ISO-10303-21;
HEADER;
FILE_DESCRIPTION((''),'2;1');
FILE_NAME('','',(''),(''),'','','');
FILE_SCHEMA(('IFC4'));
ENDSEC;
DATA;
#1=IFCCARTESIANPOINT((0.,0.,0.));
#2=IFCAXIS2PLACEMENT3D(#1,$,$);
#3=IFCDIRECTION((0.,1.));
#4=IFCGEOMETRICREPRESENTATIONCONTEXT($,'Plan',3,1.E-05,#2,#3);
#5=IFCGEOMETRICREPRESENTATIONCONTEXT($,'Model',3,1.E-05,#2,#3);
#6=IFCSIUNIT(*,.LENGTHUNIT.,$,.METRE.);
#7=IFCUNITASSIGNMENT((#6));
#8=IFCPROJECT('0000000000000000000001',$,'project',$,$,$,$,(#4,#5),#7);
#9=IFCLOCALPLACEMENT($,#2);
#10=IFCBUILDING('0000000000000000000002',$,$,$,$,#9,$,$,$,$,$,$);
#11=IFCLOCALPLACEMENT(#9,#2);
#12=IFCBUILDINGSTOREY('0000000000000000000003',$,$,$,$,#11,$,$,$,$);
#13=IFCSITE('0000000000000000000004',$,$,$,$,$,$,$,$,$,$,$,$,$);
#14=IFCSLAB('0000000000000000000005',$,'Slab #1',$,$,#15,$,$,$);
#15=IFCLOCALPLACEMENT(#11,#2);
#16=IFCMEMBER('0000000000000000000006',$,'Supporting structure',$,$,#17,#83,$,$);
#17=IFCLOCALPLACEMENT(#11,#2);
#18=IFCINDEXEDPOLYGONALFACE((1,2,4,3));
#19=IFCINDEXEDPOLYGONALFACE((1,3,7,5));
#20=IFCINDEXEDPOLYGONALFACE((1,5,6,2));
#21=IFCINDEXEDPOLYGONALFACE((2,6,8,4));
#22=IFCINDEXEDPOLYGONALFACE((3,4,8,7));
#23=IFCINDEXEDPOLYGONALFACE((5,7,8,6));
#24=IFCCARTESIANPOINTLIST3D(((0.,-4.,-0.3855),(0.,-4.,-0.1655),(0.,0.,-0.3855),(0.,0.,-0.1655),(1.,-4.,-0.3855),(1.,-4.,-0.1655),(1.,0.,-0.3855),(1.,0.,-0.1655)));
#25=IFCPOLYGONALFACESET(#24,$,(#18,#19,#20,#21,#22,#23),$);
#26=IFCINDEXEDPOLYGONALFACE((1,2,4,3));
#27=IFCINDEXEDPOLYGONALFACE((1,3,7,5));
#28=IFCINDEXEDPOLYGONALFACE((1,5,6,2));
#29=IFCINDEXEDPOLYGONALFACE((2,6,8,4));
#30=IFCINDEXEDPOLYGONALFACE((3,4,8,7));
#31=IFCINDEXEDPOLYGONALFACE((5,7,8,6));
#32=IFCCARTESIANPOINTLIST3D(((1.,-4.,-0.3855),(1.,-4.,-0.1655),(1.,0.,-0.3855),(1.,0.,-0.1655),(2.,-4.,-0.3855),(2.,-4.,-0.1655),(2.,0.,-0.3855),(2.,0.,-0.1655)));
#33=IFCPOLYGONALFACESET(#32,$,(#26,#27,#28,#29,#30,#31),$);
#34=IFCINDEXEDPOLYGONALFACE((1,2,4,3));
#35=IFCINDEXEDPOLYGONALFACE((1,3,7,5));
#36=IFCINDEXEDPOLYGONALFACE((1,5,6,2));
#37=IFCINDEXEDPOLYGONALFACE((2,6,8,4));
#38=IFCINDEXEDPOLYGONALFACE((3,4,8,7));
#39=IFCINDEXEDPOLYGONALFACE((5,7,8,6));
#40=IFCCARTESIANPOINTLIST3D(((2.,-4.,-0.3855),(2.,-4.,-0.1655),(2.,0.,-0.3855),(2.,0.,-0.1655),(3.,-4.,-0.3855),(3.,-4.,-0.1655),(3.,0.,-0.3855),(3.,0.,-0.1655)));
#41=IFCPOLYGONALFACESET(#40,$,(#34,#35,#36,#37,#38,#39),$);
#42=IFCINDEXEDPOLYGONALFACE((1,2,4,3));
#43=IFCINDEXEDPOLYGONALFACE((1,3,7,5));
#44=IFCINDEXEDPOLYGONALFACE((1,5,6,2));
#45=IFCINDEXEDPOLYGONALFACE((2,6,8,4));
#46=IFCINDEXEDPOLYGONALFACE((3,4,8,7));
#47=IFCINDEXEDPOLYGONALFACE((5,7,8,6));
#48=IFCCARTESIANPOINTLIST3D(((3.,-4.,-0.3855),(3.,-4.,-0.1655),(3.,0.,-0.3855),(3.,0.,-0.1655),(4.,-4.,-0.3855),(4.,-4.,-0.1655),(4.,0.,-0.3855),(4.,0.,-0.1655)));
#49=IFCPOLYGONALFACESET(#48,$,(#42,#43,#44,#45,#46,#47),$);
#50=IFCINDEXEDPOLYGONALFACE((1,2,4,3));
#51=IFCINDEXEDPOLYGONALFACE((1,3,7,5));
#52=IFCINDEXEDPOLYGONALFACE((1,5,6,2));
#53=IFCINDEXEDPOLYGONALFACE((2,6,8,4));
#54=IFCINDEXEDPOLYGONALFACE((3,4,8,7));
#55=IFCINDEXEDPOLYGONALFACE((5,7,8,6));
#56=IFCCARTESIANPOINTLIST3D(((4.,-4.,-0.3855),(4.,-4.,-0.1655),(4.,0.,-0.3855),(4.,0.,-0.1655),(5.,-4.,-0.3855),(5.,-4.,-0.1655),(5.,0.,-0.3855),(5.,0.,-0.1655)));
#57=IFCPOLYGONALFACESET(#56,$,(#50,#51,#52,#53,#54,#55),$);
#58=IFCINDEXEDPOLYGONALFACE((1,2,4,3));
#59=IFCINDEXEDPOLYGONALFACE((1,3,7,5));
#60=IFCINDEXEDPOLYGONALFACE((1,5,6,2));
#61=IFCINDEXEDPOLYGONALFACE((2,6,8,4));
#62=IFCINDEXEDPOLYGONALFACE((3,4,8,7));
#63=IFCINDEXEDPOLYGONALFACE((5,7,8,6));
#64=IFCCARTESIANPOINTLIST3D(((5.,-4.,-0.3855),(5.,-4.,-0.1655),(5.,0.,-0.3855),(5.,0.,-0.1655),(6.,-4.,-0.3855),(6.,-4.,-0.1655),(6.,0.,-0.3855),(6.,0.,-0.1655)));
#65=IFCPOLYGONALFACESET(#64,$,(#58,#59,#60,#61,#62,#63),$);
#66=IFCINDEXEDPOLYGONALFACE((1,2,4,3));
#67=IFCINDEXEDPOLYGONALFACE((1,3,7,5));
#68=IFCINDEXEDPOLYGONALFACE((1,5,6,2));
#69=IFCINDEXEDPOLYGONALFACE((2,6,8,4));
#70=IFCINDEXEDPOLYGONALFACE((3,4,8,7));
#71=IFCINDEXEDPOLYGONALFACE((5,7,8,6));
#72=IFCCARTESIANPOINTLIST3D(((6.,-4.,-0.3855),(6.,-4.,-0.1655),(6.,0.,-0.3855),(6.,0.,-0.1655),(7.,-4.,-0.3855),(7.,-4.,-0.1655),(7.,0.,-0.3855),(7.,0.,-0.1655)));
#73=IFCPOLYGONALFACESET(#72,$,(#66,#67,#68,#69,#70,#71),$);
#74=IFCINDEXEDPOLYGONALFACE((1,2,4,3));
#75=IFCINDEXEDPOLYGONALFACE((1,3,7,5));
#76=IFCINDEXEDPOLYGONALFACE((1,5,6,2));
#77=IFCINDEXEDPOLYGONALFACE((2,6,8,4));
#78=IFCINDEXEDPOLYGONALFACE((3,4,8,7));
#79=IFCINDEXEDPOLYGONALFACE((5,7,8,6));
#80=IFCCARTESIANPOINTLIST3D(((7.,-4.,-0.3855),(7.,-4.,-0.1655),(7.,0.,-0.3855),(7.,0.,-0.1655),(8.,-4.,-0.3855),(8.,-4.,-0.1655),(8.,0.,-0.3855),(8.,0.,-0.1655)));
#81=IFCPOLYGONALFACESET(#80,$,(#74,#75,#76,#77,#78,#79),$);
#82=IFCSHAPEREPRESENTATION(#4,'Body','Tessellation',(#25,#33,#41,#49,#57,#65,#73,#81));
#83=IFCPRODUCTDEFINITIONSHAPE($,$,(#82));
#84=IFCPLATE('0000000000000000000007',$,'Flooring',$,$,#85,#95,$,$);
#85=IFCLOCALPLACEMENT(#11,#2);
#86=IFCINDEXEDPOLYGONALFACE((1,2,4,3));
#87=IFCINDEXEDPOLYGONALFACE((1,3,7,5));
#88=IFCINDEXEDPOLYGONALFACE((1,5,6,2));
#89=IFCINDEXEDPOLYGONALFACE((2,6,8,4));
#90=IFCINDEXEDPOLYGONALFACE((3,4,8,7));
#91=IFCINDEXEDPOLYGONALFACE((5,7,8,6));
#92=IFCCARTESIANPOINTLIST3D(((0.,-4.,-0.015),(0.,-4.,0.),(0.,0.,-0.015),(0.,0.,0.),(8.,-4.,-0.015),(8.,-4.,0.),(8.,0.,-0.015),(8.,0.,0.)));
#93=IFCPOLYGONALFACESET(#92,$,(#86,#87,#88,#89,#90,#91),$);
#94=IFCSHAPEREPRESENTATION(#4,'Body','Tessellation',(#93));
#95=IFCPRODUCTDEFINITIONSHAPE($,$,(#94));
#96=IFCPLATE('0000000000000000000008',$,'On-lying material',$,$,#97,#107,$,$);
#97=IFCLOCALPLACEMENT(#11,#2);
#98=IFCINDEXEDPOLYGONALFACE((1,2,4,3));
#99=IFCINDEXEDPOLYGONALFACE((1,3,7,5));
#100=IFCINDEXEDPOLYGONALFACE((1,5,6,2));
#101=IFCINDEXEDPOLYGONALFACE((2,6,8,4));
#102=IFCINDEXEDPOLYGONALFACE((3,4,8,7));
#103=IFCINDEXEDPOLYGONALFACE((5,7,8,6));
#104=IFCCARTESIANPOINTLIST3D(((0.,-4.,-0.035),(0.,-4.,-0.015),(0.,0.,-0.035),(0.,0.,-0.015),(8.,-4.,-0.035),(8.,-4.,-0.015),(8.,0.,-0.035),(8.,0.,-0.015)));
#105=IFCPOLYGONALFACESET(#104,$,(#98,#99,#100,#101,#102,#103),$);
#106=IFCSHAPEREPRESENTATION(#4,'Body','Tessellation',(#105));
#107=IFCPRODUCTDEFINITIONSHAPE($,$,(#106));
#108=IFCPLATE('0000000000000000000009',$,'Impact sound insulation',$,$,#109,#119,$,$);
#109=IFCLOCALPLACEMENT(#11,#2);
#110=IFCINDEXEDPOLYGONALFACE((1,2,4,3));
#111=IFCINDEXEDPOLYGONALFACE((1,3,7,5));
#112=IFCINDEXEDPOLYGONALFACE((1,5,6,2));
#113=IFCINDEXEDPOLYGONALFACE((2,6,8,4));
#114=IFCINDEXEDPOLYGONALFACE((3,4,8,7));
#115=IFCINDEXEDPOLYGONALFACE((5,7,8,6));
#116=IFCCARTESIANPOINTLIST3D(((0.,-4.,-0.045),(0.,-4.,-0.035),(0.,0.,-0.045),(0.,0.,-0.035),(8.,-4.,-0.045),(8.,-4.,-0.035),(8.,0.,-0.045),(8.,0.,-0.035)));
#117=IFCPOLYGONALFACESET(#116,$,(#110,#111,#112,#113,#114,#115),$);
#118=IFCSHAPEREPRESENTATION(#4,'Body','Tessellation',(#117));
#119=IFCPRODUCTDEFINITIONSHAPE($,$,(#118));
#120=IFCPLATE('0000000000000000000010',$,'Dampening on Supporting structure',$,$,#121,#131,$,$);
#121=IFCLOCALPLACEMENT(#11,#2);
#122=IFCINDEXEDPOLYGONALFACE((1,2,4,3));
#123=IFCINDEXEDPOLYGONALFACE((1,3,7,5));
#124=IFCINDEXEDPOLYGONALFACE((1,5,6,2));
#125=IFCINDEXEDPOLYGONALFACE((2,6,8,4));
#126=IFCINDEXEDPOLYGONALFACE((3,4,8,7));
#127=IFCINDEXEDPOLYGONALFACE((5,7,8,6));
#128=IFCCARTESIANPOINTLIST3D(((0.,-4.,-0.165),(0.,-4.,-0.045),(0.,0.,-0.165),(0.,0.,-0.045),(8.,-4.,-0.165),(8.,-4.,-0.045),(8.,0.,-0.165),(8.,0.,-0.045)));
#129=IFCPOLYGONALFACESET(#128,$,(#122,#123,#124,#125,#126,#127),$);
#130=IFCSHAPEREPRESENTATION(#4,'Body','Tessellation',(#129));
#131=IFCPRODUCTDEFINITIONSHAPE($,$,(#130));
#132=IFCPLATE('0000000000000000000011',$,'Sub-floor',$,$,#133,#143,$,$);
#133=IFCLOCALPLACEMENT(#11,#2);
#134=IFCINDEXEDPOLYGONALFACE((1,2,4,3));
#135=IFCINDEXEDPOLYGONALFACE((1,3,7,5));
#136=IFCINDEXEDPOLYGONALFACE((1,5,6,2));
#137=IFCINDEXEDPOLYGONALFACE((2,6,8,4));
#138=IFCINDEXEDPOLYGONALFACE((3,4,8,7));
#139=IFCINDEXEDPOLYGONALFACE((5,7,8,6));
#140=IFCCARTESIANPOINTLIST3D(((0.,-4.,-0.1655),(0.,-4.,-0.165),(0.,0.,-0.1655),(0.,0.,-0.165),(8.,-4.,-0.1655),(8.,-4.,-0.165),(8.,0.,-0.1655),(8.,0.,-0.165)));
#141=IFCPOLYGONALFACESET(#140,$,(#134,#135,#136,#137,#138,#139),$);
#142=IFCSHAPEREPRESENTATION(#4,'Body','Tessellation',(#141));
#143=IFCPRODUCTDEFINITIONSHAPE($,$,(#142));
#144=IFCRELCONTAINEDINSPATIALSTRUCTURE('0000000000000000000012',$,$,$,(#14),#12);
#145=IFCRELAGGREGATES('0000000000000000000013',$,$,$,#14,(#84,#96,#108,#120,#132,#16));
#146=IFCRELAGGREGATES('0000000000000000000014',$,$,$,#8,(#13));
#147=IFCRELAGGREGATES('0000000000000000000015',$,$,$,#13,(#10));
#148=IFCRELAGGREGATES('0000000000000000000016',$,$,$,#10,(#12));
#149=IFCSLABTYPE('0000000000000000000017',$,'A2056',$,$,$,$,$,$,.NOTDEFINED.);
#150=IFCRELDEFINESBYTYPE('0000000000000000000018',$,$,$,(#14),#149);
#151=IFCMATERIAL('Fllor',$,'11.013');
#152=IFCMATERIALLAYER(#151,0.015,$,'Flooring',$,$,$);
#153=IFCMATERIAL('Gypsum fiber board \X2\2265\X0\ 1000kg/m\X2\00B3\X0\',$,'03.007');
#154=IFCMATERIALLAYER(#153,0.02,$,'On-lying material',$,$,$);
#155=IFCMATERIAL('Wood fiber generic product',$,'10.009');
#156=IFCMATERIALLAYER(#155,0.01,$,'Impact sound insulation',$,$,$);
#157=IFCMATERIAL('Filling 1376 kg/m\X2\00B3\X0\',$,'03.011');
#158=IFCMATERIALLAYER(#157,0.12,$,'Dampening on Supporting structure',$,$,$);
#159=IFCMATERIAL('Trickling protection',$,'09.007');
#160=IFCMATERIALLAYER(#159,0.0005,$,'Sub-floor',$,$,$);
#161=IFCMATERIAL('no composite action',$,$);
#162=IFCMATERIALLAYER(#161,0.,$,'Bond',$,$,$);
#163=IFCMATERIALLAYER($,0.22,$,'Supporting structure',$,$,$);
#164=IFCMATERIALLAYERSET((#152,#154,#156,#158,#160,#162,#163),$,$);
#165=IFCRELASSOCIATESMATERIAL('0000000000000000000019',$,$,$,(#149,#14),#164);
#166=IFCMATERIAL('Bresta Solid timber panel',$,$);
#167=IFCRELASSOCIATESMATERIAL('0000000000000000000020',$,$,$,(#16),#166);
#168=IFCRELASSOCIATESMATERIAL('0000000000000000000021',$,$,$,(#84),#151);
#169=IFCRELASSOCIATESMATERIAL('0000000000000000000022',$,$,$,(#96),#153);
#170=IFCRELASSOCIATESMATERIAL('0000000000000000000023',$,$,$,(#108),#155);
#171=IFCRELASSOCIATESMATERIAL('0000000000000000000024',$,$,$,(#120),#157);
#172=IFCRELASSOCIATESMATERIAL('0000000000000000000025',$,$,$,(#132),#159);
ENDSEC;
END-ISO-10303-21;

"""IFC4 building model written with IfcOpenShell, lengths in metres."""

from ifc_helpers import new_model, si_unit, direction, frame, frame_2d, origin, origin_with_axes, place, context, project, spatial, rectangle, extrude, material, layer, layer_set, type_object, element, aggregate, save


model = new_model("IFC4")

# Units and contexts
plan_context = context("Plan", 3, precision=1e-05, world=origin(), true_north=direction((0.0, 1.0)))
model_context = context("Model", 3, precision=1e-05, world=origin(), true_north=direction((0.0, 1.0)))
ifc_project = project(units=[si_unit("LENGTHUNIT", "METRE")], contexts=[plan_context, model_context])

# Site, building, storey
site = spatial("IfcSite", under=ifc_project)
building_placement = place(None, origin())
building = spatial("IfcBuilding", under=site, at=building_placement)
storey_placement = place(building_placement, origin())
storey = spatial("IfcBuildingStorey", under=building, at=storey_placement)

# Slab, member, plates
ifc_material_1 = material(Name="Fllor", Category="11.013")
ifc_layer_1 = layer(ifc_material_1, 0.015, Name="Flooring")
ifc_material_2 = material(Name="Gypsum fiber board ≥ 1000kg/m³", Category="03.007")
ifc_layer_2 = layer(ifc_material_2, 0.02, Name="On-lying material")
ifc_material_3 = material(Name="Wood fiber generic product", Category="10.009")
ifc_layer_3 = layer(ifc_material_3, 0.01, Name="Impact sound insulation")
ifc_material_4 = material(Name="Filling 1376 kg/m³", Category="03.011")
ifc_layer_4 = layer(ifc_material_4, 0.12, Name="Dampening on Supporting structure")
ifc_material_5 = material(Name="Trickling protection", Category="09.007")
ifc_layer_5 = layer(ifc_material_5, 0.0005, Name="Sub-floor")
ifc_material_6 = material(Name="no composite action")
ifc_layer_6 = layer(ifc_material_6, 0.0, Name="Bond")
ifc_layer_7 = layer(None, 0.22, Name="Supporting structure")
ifc_layer_set = layer_set([ifc_layer_1, ifc_layer_2, ifc_layer_3, ifc_layer_4, ifc_layer_5, ifc_layer_6, ifc_layer_7])
slab_type = type_object("IfcSlabType", Name="A2056", PredefinedType="NOTDEFINED", material=ifc_layer_set)
slab_placement = place(None, frame((0.0, 0.0, 0.0), z_axis=(0.0, 0.0, -1.0), x_axis=(1.0, 0.0, 0.0)))
slab = element("IfcSlab", 1, at=slab_placement, inside=storey, type_object=slab_type, material=ifc_layer_set, Name="Slab #1")
ifc_material_7 = material(Name="Bresta Solid timber panel")
member_placement = place(slab_placement, origin())
member = element("IfcMember", 2, at=member_placement, material=ifc_material_7, Name="Supporting structure", context=plan_context, shape_type="SweptSolid", body=[
    extrude(rectangle(XDim=1.0, YDim=0.22, at=frame_2d((0.5, 0.11), x_axis=(1.0, 0.0))), frame((0.0, 4.0, 0.1655), z_axis=(0.0, -1.0, 0.0), x_axis=(1.0, 0.0, 0.0)), (0.0, 0.0, 1.0), 4.0),
    extrude(rectangle(XDim=1.0, YDim=0.22, at=frame_2d((0.5, 0.11), x_axis=(1.0, 0.0))), frame((1.0, 4.0, 0.1655), z_axis=(0.0, -1.0, 0.0), x_axis=(1.0, 0.0, 0.0)), (0.0, 0.0, 1.0), 4.0),
    extrude(rectangle(XDim=1.0, YDim=0.22, at=frame_2d((0.5, 0.11), x_axis=(1.0, 0.0))), frame((2.0, 4.0, 0.1655), z_axis=(0.0, -1.0, 0.0), x_axis=(1.0, 0.0, 0.0)), (0.0, 0.0, 1.0), 4.0),
    extrude(rectangle(XDim=1.0, YDim=0.22, at=frame_2d((0.5, 0.11), x_axis=(1.0, 0.0))), frame((3.0, 4.0, 0.1655), z_axis=(0.0, -1.0, 0.0), x_axis=(1.0, 0.0, 0.0)), (0.0, 0.0, 1.0), 4.0),
    extrude(rectangle(XDim=1.0, YDim=0.22, at=frame_2d((0.5, 0.11), x_axis=(1.0, 0.0))), frame((4.0, 4.0, 0.1655), z_axis=(0.0, -1.0, 0.0), x_axis=(1.0, 0.0, 0.0)), (0.0, 0.0, 1.0), 4.0),
    extrude(rectangle(XDim=1.0, YDim=0.22, at=frame_2d((0.5, 0.11), x_axis=(1.0, 0.0))), frame((5.0, 4.0, 0.1655), z_axis=(0.0, -1.0, 0.0), x_axis=(1.0, 0.0, 0.0)), (0.0, 0.0, 1.0), 4.0),
    extrude(rectangle(XDim=1.0, YDim=0.22, at=frame_2d((0.5, 0.11), x_axis=(1.0, 0.0))), frame((6.0, 4.0, 0.1655), z_axis=(0.0, -1.0, 0.0), x_axis=(1.0, 0.0, 0.0)), (0.0, 0.0, 1.0), 4.0),
    extrude(rectangle(XDim=1.0, YDim=0.22, at=frame_2d((0.5, 0.11), x_axis=(1.0, 0.0))), frame((7.0, 4.0, 0.1655), z_axis=(0.0, -1.0, 0.0), x_axis=(1.0, 0.0, 0.0)), (0.0, 0.0, 1.0), 4.0),
])
plate_1_placement = place(slab_placement, origin())
plate_1 = element("IfcPlate", 3, at=plate_1_placement, material=ifc_material_1, Name="Flooring", context=plan_context, shape_type="SweptSolid", body=[
    extrude(rectangle(XDim=8.0, YDim=4.0, at=frame_2d((4.0, 2.0), x_axis=(1.0, 0.0))), origin_with_axes(), (0.0, 0.0, 1.0), 0.015),
])
plate_2_placement = place(slab_placement, origin())
plate_2 = element("IfcPlate", 4, at=plate_2_placement, material=ifc_material_2, Name="On-lying material", context=plan_context, shape_type="SweptSolid", body=[
    extrude(rectangle(XDim=8.0, YDim=4.0, at=frame_2d((4.0, 2.0), x_axis=(1.0, 0.0))), frame((0.0, 0.0, 0.015), z_axis=(0.0, 0.0, 1.0), x_axis=(1.0, 0.0, 0.0)), (0.0, 0.0, 1.0), 0.02),
])
plate_3_placement = place(slab_placement, origin())
plate_3 = element("IfcPlate", 5, at=plate_3_placement, material=ifc_material_3, Name="Impact sound insulation", context=plan_context, shape_type="SweptSolid", body=[
    extrude(rectangle(XDim=8.0, YDim=4.0, at=frame_2d((4.0, 2.0), x_axis=(1.0, 0.0))), frame((0.0, 0.0, 0.035), z_axis=(0.0, 0.0, 1.0), x_axis=(1.0, 0.0, 0.0)), (0.0, 0.0, 1.0), 0.01),
])
plate_4_placement = place(slab_placement, origin())
plate_4 = element("IfcPlate", 6, at=plate_4_placement, material=ifc_material_4, Name="Dampening on Supporting structure", context=plan_context, shape_type="SweptSolid", body=[
    extrude(rectangle(XDim=8.0, YDim=4.0, at=frame_2d((4.0, 2.0), x_axis=(1.0, 0.0))), frame((0.0, 0.0, 0.045), z_axis=(0.0, 0.0, 1.0), x_axis=(1.0, 0.0, 0.0)), (0.0, 0.0, 1.0), 0.12),
])
plate_5_placement = place(slab_placement, origin())
plate_5 = element("IfcPlate", 7, at=plate_5_placement, material=ifc_material_5, Name="Sub-floor", context=plan_context, shape_type="SweptSolid", body=[
    extrude(rectangle(XDim=8.0, YDim=4.0, at=frame_2d((4.0, 2.0), x_axis=(1.0, 0.0))), frame((0.0, 0.0, 0.165), z_axis=(0.0, 0.0, 1.0), x_axis=(1.0, 0.0, 0.0)), (0.0, 0.0, 1.0), 0.0005),
])
aggregate(slab, [plate_1, plate_2, plate_3, plate_4, plate_5, member])

save(model, "model.ifc")
